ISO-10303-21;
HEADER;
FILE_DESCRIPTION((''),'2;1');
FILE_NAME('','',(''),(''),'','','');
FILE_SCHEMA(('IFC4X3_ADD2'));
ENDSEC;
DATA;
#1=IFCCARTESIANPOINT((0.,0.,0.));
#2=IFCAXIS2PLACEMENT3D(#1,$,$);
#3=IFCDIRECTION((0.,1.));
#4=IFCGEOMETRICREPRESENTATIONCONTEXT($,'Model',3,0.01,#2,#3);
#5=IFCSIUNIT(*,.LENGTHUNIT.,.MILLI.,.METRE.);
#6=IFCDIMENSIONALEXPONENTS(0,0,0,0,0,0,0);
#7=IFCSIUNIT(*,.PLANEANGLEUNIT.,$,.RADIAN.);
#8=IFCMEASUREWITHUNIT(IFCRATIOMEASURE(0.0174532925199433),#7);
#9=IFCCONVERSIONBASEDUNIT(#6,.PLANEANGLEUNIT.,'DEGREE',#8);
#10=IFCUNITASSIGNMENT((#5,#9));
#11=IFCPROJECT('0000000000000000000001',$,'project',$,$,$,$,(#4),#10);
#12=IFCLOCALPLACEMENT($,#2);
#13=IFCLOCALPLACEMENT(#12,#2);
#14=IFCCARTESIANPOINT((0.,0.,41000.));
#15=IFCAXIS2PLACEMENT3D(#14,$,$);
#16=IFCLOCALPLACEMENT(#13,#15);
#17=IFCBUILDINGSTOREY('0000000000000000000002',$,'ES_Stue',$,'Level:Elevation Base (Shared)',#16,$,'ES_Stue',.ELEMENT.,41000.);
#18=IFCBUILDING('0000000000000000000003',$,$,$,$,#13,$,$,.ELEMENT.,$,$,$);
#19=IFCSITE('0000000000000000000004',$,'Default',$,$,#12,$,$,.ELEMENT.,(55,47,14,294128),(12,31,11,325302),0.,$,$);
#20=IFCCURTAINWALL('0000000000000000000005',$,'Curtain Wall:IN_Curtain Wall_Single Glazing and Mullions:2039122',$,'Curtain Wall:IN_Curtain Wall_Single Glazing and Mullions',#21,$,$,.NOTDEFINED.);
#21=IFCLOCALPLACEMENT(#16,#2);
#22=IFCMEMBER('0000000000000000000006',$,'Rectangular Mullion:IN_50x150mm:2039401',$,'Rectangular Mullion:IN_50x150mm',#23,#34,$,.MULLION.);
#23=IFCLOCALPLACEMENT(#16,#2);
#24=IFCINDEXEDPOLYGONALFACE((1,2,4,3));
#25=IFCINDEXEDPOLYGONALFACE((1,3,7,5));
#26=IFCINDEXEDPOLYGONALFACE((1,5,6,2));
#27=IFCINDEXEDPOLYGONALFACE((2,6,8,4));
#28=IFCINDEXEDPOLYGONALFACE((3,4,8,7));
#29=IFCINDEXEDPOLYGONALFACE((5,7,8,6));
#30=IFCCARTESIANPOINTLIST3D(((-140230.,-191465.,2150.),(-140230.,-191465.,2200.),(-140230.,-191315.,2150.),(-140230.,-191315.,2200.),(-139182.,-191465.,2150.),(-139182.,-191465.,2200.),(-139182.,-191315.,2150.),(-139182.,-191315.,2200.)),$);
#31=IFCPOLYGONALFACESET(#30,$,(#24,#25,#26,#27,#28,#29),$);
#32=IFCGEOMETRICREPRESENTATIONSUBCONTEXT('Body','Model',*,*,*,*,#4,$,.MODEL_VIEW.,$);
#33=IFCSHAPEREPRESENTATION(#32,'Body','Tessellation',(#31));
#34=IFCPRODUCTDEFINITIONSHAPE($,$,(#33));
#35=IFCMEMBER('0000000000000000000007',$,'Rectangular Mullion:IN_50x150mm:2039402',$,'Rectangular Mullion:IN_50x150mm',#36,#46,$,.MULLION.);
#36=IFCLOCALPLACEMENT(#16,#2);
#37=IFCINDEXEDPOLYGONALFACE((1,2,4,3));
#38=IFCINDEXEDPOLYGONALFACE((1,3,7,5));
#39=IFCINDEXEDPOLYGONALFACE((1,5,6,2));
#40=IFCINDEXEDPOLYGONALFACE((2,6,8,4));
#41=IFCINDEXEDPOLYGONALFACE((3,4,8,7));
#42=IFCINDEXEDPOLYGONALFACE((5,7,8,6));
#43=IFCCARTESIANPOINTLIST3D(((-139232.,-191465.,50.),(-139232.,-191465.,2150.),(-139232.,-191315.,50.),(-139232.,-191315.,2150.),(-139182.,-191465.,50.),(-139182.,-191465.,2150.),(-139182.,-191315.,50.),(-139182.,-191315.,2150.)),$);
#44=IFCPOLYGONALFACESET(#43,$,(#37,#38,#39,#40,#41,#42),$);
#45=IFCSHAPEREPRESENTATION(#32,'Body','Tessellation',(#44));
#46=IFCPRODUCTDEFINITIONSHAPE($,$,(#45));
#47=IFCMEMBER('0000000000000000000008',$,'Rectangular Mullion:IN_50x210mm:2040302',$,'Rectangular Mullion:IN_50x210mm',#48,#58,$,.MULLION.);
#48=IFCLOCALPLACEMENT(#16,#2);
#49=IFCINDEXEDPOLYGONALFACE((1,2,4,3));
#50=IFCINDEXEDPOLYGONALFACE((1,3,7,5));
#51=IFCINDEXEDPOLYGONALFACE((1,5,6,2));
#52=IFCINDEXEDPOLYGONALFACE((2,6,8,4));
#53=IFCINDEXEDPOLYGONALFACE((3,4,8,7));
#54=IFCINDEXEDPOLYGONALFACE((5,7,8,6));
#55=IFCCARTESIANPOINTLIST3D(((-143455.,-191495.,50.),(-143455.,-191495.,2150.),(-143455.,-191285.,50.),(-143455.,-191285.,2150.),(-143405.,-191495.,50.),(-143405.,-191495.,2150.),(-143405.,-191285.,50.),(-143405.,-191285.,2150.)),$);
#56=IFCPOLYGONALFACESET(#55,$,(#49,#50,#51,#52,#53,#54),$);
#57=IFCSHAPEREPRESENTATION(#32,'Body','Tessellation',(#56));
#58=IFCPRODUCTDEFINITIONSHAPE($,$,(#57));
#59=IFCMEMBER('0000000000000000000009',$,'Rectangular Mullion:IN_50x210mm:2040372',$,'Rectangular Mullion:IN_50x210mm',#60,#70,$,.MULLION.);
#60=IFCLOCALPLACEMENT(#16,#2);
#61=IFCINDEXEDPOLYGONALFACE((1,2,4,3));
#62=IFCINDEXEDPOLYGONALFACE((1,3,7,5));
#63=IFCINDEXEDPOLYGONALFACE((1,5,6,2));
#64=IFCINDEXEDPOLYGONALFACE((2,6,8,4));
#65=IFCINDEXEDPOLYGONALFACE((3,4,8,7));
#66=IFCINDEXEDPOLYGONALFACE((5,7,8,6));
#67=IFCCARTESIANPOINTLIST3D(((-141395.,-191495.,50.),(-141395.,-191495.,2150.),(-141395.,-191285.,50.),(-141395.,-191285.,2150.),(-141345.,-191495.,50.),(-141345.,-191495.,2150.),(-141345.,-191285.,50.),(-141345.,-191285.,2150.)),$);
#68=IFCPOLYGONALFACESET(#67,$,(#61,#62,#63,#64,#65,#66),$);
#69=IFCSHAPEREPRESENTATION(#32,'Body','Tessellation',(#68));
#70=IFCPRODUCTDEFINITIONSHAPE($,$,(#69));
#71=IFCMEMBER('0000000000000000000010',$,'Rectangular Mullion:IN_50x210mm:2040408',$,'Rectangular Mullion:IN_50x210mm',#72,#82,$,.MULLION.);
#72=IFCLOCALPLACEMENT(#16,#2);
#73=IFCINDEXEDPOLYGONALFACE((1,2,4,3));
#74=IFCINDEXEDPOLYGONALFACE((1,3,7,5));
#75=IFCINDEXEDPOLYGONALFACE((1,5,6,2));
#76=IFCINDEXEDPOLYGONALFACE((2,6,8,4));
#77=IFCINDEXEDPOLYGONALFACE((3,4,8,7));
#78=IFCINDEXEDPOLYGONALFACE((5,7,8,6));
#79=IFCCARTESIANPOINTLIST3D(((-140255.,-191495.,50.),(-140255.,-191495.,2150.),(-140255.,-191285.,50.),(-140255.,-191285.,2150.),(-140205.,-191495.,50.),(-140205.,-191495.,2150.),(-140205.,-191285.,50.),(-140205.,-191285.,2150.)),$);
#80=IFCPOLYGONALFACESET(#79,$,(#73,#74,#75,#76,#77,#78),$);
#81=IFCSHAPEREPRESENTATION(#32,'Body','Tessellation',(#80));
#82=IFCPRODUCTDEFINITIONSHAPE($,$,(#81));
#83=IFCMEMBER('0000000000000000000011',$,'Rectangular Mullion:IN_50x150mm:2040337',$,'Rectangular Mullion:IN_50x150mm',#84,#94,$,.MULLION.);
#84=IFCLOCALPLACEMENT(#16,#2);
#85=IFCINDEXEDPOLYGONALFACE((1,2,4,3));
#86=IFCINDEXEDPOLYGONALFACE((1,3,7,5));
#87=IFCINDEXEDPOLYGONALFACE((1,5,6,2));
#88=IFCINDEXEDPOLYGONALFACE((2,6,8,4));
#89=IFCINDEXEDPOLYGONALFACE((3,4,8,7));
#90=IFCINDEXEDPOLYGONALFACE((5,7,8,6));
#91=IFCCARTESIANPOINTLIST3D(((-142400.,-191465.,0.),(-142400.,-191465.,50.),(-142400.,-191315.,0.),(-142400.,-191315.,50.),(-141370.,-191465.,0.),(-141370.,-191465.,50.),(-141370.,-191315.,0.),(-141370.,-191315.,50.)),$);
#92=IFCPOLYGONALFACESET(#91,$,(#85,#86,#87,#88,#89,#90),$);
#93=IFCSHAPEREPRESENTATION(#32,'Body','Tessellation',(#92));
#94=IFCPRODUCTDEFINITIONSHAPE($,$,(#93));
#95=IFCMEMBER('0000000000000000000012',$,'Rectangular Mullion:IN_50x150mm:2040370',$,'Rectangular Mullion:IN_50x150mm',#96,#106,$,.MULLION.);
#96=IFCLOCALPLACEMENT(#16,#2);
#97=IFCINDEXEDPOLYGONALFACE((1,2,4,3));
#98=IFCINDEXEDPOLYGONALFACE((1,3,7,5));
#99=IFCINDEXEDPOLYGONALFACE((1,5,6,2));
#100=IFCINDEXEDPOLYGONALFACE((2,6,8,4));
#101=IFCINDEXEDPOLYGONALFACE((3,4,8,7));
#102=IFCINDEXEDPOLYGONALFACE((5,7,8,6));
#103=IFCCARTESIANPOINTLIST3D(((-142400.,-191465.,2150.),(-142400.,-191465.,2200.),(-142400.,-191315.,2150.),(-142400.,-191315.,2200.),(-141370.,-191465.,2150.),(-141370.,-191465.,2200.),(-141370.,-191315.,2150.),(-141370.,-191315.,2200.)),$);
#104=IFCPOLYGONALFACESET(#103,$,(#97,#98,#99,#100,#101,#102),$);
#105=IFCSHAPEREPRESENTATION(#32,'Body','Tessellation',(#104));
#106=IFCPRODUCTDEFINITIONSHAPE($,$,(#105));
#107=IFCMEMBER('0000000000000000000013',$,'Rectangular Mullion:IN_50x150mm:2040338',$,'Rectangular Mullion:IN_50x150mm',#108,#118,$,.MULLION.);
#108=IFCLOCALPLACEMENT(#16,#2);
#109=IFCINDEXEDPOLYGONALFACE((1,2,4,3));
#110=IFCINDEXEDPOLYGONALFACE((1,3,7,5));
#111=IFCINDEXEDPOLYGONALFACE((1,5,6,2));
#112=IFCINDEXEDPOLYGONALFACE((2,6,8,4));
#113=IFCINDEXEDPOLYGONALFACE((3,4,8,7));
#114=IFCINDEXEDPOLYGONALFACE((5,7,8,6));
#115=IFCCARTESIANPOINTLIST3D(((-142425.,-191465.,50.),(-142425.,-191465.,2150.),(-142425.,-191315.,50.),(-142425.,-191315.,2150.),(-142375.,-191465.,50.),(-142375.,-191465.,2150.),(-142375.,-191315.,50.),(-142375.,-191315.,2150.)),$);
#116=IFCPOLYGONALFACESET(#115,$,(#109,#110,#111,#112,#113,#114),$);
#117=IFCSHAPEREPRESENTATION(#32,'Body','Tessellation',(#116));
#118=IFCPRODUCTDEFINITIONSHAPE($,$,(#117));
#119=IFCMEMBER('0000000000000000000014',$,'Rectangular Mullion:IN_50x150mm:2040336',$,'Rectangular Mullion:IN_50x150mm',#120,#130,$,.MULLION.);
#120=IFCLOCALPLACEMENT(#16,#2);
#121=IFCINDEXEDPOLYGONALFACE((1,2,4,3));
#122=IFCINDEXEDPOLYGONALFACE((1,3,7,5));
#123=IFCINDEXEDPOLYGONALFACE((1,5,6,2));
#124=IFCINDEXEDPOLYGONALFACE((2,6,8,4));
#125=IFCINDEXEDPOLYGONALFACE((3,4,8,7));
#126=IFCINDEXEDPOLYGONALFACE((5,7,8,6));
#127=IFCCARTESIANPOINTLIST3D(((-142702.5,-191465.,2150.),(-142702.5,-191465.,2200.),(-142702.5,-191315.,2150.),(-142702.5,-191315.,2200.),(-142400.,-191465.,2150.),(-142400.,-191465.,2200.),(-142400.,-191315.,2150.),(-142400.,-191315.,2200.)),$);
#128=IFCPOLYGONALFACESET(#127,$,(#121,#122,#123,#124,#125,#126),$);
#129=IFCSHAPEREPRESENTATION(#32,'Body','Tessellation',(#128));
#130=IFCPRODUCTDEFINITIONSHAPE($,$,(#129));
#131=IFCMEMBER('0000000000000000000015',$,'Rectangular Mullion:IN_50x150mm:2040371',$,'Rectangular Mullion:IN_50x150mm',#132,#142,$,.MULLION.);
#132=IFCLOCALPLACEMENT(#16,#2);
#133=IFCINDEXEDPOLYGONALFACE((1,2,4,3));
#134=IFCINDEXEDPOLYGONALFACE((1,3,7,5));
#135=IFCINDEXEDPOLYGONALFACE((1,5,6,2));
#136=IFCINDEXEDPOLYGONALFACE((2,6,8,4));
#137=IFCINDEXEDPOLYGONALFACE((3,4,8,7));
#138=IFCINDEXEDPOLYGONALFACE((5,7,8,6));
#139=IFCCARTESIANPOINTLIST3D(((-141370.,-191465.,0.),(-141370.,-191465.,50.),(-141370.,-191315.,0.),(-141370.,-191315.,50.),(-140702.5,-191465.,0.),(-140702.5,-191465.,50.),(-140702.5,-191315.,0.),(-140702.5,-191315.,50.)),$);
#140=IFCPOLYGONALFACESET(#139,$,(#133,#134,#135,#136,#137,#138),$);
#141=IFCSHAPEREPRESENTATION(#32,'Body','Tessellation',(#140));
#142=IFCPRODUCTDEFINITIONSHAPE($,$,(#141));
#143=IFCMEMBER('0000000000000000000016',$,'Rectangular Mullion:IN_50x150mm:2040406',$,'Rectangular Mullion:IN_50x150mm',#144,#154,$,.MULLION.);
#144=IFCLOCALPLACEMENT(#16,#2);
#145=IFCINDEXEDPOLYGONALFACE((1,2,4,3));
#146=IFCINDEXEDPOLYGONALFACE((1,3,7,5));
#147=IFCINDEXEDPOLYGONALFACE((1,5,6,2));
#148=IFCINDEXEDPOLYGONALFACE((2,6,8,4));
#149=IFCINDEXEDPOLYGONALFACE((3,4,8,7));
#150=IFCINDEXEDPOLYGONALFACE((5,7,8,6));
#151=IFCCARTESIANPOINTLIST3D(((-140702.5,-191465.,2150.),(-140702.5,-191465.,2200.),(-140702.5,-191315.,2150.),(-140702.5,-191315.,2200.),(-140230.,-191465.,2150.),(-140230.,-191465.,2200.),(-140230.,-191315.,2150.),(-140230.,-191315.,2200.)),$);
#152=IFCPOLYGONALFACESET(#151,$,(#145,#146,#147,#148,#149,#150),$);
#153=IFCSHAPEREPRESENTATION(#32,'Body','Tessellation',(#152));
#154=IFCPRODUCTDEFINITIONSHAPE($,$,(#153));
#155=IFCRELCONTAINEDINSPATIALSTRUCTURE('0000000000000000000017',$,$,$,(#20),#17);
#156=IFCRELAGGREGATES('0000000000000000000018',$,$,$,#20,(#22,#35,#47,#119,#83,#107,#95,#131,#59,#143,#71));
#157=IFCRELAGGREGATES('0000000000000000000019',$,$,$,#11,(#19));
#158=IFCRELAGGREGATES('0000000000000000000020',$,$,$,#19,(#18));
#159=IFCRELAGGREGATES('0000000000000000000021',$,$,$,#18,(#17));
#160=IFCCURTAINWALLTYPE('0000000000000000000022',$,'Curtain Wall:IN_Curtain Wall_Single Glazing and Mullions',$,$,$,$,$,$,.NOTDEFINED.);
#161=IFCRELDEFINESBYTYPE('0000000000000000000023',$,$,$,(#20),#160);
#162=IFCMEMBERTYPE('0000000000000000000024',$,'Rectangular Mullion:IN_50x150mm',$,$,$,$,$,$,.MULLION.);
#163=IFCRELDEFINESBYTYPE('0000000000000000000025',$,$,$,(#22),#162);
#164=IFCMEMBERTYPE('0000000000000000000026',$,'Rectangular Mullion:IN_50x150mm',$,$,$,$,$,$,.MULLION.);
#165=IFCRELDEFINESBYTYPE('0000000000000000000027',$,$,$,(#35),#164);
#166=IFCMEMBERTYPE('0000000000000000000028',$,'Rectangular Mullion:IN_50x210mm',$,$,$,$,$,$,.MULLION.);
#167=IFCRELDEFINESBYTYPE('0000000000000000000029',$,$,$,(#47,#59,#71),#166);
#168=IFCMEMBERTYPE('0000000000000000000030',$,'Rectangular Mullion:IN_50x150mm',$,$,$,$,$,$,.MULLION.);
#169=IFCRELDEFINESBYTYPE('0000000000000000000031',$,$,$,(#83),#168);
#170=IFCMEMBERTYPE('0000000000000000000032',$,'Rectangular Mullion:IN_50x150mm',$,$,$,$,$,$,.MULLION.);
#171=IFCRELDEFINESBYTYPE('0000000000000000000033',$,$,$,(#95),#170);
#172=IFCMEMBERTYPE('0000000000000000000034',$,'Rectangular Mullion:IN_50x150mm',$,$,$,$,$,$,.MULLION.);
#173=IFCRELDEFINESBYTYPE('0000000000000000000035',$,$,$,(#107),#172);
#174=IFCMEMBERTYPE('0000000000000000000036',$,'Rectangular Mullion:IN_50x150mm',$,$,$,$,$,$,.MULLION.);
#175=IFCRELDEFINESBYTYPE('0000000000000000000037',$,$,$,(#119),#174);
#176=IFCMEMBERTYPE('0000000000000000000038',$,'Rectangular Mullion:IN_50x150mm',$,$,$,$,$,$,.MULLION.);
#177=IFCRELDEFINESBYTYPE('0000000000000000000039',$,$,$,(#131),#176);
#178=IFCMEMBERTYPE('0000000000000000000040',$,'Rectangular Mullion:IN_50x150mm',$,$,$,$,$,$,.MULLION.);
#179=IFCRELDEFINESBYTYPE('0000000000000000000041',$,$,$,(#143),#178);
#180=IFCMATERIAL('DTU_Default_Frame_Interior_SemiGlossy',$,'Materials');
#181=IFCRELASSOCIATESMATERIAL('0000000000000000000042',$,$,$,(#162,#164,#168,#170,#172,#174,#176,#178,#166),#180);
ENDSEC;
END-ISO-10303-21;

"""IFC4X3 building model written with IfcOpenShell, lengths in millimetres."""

from ifc_helpers import new_model, entity, si_unit, converted_unit, direction, frame, origin, origin_2d_with_axis, place, context, subcontext, project, spatial, rectangle, extrude, source, transform, mapped, material, material_profile, profile_set, type_object, type_shapes, element, aggregate, save


model = new_model("IFC4X3")

# Units and contexts
model_context = context("Model", 3, precision=0.01, world=origin(), true_north=direction((0.0, 1.0)))
body_context = subcontext(model_context, "Body", "Model", "MODEL_VIEW")
ifc_project = project(units=[si_unit("LENGTHUNIT", "METRE", prefix="MILLI"), converted_unit("PLANEANGLEUNIT", "DEGREE", entity("IfcRatioMeasure", 0.0174532925199433), si_unit("PLANEANGLEUNIT", "RADIAN"), dimensions=[0, 0, 0, 0, 0, 0, 0])], contexts=[model_context])

# Site, building, storey
site_placement = place(None, origin())
site = spatial("IfcSite", under=ifc_project, at=site_placement, Name="Default", CompositionType="ELEMENT", RefLatitude=(55, 47, 14, 294128), RefLongitude=(12, 31, 11, 325302), RefElevation=0.0)
building_placement = place(site_placement, origin())
building = spatial("IfcBuilding", under=site, at=building_placement, CompositionType="ELEMENT")
storey_placement = place(building_placement, frame((0.0, 0.0, 41000.0)))
storey = spatial("IfcBuildingStorey", under=building, at=storey_placement, Name="ES_Stue", ObjectType="Level:Elevation Base (Shared)", LongName="ES_Stue", CompositionType="ELEMENT", Elevation=41000.0)

# Curtain wall, members
curtain_wall_type_1 = type_object("IfcCurtainWallType", Name="Curtain Wall:IN_Curtain Wall_Single Glazing and Mullions", PredefinedType="NOTDEFINED")
curtain_wall_1_placement = place(storey_placement, frame((0.0, 0.0, -41000.0)))
curtain_wall_1 = element("IfcCurtainWall", 1, at=curtain_wall_1_placement, inside=storey, type_object=curtain_wall_type_1, Name="Curtain Wall:IN_Curtain Wall_Single Glazing and Mullions:2039122", ObjectType="Curtain Wall:IN_Curtain Wall_Single Glazing and Mullions", PredefinedType="NOTDEFINED")
ifc_material_1 = material(Name="DTU_Default_Frame_Interior_SemiGlossy", Category="Materials")
ifc_material_profile_1 = material_profile(ifc_material_1, rectangle(XDim=150.0, YDim=50.0, at=origin_2d_with_axis()), Name="IN_50x150mm")
ifc_profile_set_1 = profile_set([ifc_material_profile_1], Name="IN_50x150mm")
member_type_1 = type_object("IfcMemberType", Name="Rectangular Mullion:IN_50x150mm", PredefinedType="MULLION", material=ifc_profile_set_1)
shared_shape_1 = source(origin(), body_context, "Body", "SweptSolid", [
    extrude(rectangle(XDim=150.0, YDim=50.0, at=origin_2d_with_axis()), frame((-25.0, 0.0, -1048.0), z_axis=(0.0, 0.0, 1.0), x_axis=(0.0, -1.0, 0.0)), (0.0, 0.0, 1.0), 1048.0),
])
type_shapes(member_type_1, [shared_shape_1])
member_1_placement = place(curtain_wall_1_placement, frame((-139182.0, -191390.0, 43200.0), z_axis=(1.0, 0.0, 0.0), x_axis=(0.0, 0.0, 1.0)))
member_1 = element("IfcMember", 2, at=member_1_placement, type_object=member_type_1, Name="Rectangular Mullion:IN_50x150mm:2039401", ObjectType="Rectangular Mullion:IN_50x150mm", PredefinedType="MULLION", context=body_context, shape_type="MappedRepresentation", body=[
    mapped(shared_shape_1, transform((0.0, 0.0, 0.0), scale=1.0)),
])
member_type_2 = type_object("IfcMemberType", Name="Rectangular Mullion:IN_50x150mm", PredefinedType="MULLION", material=ifc_profile_set_1)
shared_shape_2 = source(origin(), body_context, "Body", "SweptSolid", [
    extrude(rectangle(XDim=150.0, YDim=50.0, at=origin_2d_with_axis()), frame((-25.0, 0.0, -2100.0), z_axis=(0.0, 0.0, 1.0), x_axis=(0.0, -1.0, 0.0)), (0.0, 0.0, 1.0), 2100.0),
])
type_shapes(member_type_2, [shared_shape_2])
member_2_placement = place(curtain_wall_1_placement, frame((-139182.0, -191390.0, 41050.0), z_axis=(0.0, 0.0, -1.0), x_axis=(1.0, 0.0, 0.0)))
member_2 = element("IfcMember", 3, at=member_2_placement, type_object=member_type_2, Name="Rectangular Mullion:IN_50x150mm:2039402", ObjectType="Rectangular Mullion:IN_50x150mm", PredefinedType="MULLION", context=body_context, shape_type="MappedRepresentation", body=[
    mapped(shared_shape_2, transform((0.0, 0.0, 0.0), scale=1.0)),
])
ifc_material_profile_2 = material_profile(ifc_material_1, rectangle(XDim=210.0, YDim=50.0, at=origin_2d_with_axis()), Name="IN_50x210mm")
ifc_profile_set_2 = profile_set([ifc_material_profile_2], Name="IN_50x210mm")
member_type_3 = type_object("IfcMemberType", Name="Rectangular Mullion:IN_50x210mm", PredefinedType="MULLION", material=ifc_profile_set_2)
shared_shape_3 = source(origin(), body_context, "Body", "SweptSolid", [
    extrude(rectangle(XDim=210.0, YDim=50.0, at=origin_2d_with_axis()), frame((0.0, 0.0, -2100.0), z_axis=(0.0, 0.0, 1.0), x_axis=(0.0, -1.0, 0.0)), (0.0, 0.0, 1.0), 2100.0),
])
type_shapes(member_type_3, [shared_shape_3])
member_3_placement = place(curtain_wall_1_placement, frame((-143430.0, -191390.0, 41050.0), z_axis=(0.0, 0.0, -1.0), x_axis=(1.0, 0.0, 0.0)))
member_3 = element("IfcMember", 4, at=member_3_placement, type_object=member_type_3, Name="Rectangular Mullion:IN_50x210mm:2040302", ObjectType="Rectangular Mullion:IN_50x210mm", PredefinedType="MULLION", context=body_context, shape_type="MappedRepresentation", body=[
    mapped(shared_shape_3, transform((0.0, 0.0, 0.0), scale=1.0)),
])
member_4_placement = place(curtain_wall_1_placement, frame((-141370.0, -191390.0, 41050.0), z_axis=(0.0, 0.0, -1.0), x_axis=(1.0, 0.0, 0.0)))
member_4 = element("IfcMember", 5, at=member_4_placement, type_object=member_type_3, Name="Rectangular Mullion:IN_50x210mm:2040372", ObjectType="Rectangular Mullion:IN_50x210mm", PredefinedType="MULLION", context=body_context, shape_type="MappedRepresentation", body=[
    mapped(shared_shape_3, transform((0.0, 0.0, 0.0), scale=1.0)),
])
member_5_placement = place(curtain_wall_1_placement, frame((-140230.0, -191390.0, 41050.0), z_axis=(0.0, 0.0, -1.0), x_axis=(1.0, 0.0, 0.0)))
member_5 = element("IfcMember", 6, at=member_5_placement, type_object=member_type_3, Name="Rectangular Mullion:IN_50x210mm:2040408", ObjectType="Rectangular Mullion:IN_50x210mm", PredefinedType="MULLION", context=body_context, shape_type="MappedRepresentation", body=[
    mapped(shared_shape_3, transform((0.0, 0.0, 0.0), scale=1.0)),
])
member_type_4 = type_object("IfcMemberType", Name="Rectangular Mullion:IN_50x150mm", PredefinedType="MULLION", material=ifc_profile_set_1)
shared_shape_4 = source(origin(), body_context, "Body", "SweptSolid", [
    extrude(rectangle(XDim=150.0, YDim=50.0, at=origin_2d_with_axis()), frame((-25.0, 0.0, -1030.0), z_axis=(0.0, 0.0, 1.0), x_axis=(0.0, -1.0, 0.0)), (0.0, 0.0, 1.0), 1030.0),
])
type_shapes(member_type_4, [shared_shape_4])
member_6_placement = place(curtain_wall_1_placement, frame((-142400.0, -191390.0, 41000.0), z_axis=(-1.0, 0.0, 0.0), x_axis=(0.0, 0.0, -1.0)))
member_6 = element("IfcMember", 7, at=member_6_placement, type_object=member_type_4, Name="Rectangular Mullion:IN_50x150mm:2040337", ObjectType="Rectangular Mullion:IN_50x150mm", PredefinedType="MULLION", context=body_context, shape_type="MappedRepresentation", body=[
    mapped(shared_shape_4, transform((0.0, 0.0, 0.0), scale=1.0)),
])
member_type_5 = type_object("IfcMemberType", Name="Rectangular Mullion:IN_50x150mm", PredefinedType="MULLION", material=ifc_profile_set_1)
shared_shape_5 = source(origin(), body_context, "Body", "SweptSolid", [
    extrude(rectangle(XDim=150.0, YDim=50.0, at=origin_2d_with_axis()), frame((-25.0, 0.0, -1030.0), z_axis=(0.0, 0.0, 1.0), x_axis=(0.0, -1.0, 0.0)), (0.0, 0.0, 1.0), 1030.0),
])
type_shapes(member_type_5, [shared_shape_5])
member_7_placement = place(curtain_wall_1_placement, frame((-141370.0, -191390.0, 43200.0), z_axis=(1.0, 0.0, 0.0), x_axis=(0.0, 0.0, 1.0)))
member_7 = element("IfcMember", 8, at=member_7_placement, type_object=member_type_5, Name="Rectangular Mullion:IN_50x150mm:2040370", ObjectType="Rectangular Mullion:IN_50x150mm", PredefinedType="MULLION", context=body_context, shape_type="MappedRepresentation", body=[
    mapped(shared_shape_5, transform((0.0, 0.0, 0.0), scale=1.0)),
])
member_type_6 = type_object("IfcMemberType", Name="Rectangular Mullion:IN_50x150mm", PredefinedType="MULLION", material=ifc_profile_set_1)
shared_shape_6 = source(origin(), body_context, "Body", "SweptSolid", [
    extrude(rectangle(XDim=150.0, YDim=50.0, at=origin_2d_with_axis()), frame((0.0, 0.0, -2100.0), z_axis=(0.0, 0.0, 1.0), x_axis=(0.0, -1.0, 0.0)), (0.0, 0.0, 1.0), 2100.0),
])
type_shapes(member_type_6, [shared_shape_6])
member_8_placement = place(curtain_wall_1_placement, frame((-142400.0, -191390.0, 41050.0), z_axis=(0.0, 0.0, -1.0), x_axis=(1.0, 0.0, 0.0)))
member_8 = element("IfcMember", 9, at=member_8_placement, type_object=member_type_6, Name="Rectangular Mullion:IN_50x150mm:2040338", ObjectType="Rectangular Mullion:IN_50x150mm", PredefinedType="MULLION", context=body_context, shape_type="MappedRepresentation", body=[
    mapped(shared_shape_6, transform((0.0, 0.0, 0.0), scale=1.0)),
])
member_type_7 = type_object("IfcMemberType", Name="Rectangular Mullion:IN_50x150mm", PredefinedType="MULLION", material=ifc_profile_set_1)
shared_shape_7 = source(origin(), body_context, "Body", "SweptSolid", [
    extrude(rectangle(XDim=150.0, YDim=50.0, at=origin_2d_with_axis()), frame((-25.0, 0.0, -302.5), z_axis=(0.0, 0.0, 1.0), x_axis=(0.0, -1.0, 0.0)), (0.0, 0.0, 1.0), 302.5),
])
type_shapes(member_type_7, [shared_shape_7])
member_9_placement = place(curtain_wall_1_placement, frame((-142400.0, -191390.0, 43200.0), z_axis=(1.0, 0.0, 0.0), x_axis=(0.0, 0.0, 1.0)))
member_9 = element("IfcMember", 10, at=member_9_placement, type_object=member_type_7, Name="Rectangular Mullion:IN_50x150mm:2040336", ObjectType="Rectangular Mullion:IN_50x150mm", PredefinedType="MULLION", context=body_context, shape_type="MappedRepresentation", body=[
    mapped(shared_shape_7, transform((0.0, 0.0, 0.0), scale=1.0)),
])
member_type_8 = type_object("IfcMemberType", Name="Rectangular Mullion:IN_50x150mm", PredefinedType="MULLION", material=ifc_profile_set_1)
shared_shape_8 = source(origin(), body_context, "Body", "SweptSolid", [
    extrude(rectangle(XDim=150.0, YDim=50.0, at=origin_2d_with_axis()), frame((-25.0, 0.0, -667.5), z_axis=(0.0, 0.0, 1.0), x_axis=(0.0, -1.0, 0.0)), (0.0, 0.0, 1.0), 667.5),
])
type_shapes(member_type_8, [shared_shape_8])
member_10_placement = place(curtain_wall_1_placement, frame((-141370.0, -191390.0, 41000.0), z_axis=(-1.0, 0.0, 0.0), x_axis=(0.0, 0.0, -1.0)))
member_10 = element("IfcMember", 11, at=member_10_placement, type_object=member_type_8, Name="Rectangular Mullion:IN_50x150mm:2040371", ObjectType="Rectangular Mullion:IN_50x150mm", PredefinedType="MULLION", context=body_context, shape_type="MappedRepresentation", body=[
    mapped(shared_shape_8, transform((0.0, 0.0, 0.0), scale=1.0)),
])
member_type_9 = type_object("IfcMemberType", Name="Rectangular Mullion:IN_50x150mm", PredefinedType="MULLION", material=ifc_profile_set_1)
shared_shape_9 = source(origin(), body_context, "Body", "SweptSolid", [
    extrude(rectangle(XDim=150.0, YDim=50.0, at=origin_2d_with_axis()), frame((-25.0, 0.0, -472.5), z_axis=(0.0, 0.0, 1.0), x_axis=(0.0, -1.0, 0.0)), (0.0, 0.0, 1.0), 472.5),
])
type_shapes(member_type_9, [shared_shape_9])
member_11_placement = place(curtain_wall_1_placement, frame((-140230.0, -191390.0, 43200.0), z_axis=(1.0, 0.0, 0.0), x_axis=(0.0, 0.0, 1.0)))
member_11 = element("IfcMember", 12, at=member_11_placement, type_object=member_type_9, Name="Rectangular Mullion:IN_50x150mm:2040406", ObjectType="Rectangular Mullion:IN_50x150mm", PredefinedType="MULLION", context=body_context, shape_type="MappedRepresentation", body=[
    mapped(shared_shape_9, transform((0.0, 0.0, 0.0), scale=1.0)),
])
aggregate(curtain_wall_1, [member_1, member_2, member_3, member_9, member_6, member_8, member_7, member_10, member_4, member_11, member_5])

save(model, "model.ifc")
